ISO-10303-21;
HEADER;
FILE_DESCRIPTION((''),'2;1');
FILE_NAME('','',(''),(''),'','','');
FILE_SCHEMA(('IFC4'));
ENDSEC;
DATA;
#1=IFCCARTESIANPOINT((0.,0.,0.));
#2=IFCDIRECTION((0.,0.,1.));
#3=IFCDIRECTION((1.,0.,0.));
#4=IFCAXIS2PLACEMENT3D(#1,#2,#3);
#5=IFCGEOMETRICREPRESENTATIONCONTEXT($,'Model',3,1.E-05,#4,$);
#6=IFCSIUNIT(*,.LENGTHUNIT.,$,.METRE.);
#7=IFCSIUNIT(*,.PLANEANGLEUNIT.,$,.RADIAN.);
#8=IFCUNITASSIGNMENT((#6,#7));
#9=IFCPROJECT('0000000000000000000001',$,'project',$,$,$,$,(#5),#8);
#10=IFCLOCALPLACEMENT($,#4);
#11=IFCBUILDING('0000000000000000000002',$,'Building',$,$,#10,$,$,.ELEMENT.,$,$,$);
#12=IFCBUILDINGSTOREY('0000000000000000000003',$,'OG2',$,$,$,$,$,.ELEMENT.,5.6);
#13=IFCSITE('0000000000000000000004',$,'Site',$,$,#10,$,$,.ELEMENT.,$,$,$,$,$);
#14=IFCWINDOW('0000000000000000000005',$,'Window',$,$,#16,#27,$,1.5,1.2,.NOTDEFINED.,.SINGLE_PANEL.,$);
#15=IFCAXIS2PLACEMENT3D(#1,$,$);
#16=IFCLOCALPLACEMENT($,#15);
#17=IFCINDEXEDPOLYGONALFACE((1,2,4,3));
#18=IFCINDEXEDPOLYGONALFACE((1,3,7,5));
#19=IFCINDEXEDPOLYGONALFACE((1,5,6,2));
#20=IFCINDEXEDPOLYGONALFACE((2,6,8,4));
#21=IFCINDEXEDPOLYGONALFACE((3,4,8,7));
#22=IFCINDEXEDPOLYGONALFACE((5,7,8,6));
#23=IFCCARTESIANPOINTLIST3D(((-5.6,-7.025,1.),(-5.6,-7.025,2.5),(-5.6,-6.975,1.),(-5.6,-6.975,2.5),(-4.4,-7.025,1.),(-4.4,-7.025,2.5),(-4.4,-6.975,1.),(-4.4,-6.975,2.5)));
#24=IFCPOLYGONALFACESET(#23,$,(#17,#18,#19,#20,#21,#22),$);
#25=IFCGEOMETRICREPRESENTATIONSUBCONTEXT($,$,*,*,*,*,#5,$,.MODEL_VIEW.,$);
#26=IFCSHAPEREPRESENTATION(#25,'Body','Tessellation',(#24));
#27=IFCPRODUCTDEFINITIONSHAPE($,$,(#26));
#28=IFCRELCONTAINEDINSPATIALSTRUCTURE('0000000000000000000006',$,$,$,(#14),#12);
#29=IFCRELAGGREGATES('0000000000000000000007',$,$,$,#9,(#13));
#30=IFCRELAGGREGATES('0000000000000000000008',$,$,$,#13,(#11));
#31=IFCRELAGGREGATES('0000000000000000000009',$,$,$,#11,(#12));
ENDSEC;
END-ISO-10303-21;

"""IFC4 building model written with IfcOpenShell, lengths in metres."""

from ifc_helpers import new_model, si_unit, frame, origin, origin_with_axes, origin_2d, place, context, subcontext, project, spatial, rectangle, extrude, element, save


model = new_model("IFC4")

# Units and contexts
model_context = context("Model", 3, precision=1e-05, world=origin_with_axes())
sub_context = subcontext(model_context, None, None, "MODEL_VIEW")
ifc_project = project(units=[si_unit("LENGTHUNIT", "METRE"), si_unit("PLANEANGLEUNIT", "RADIAN")], contexts=[model_context])

# Site, building, storey
placement_1 = place(None, origin_with_axes())
site = spatial("IfcSite", under=ifc_project, at=placement_1, Name="Site", CompositionType="ELEMENT")
building = spatial("IfcBuilding", under=site, at=placement_1, Name="Building", CompositionType="ELEMENT")
storey = spatial("IfcBuildingStorey", under=building, Name="OG2", CompositionType="ELEMENT", Elevation=5.6)

# Window
placement_2 = place(None, origin_with_axes())
window_placement = place(placement_2, frame((-5.0, -7.0, 1.0)))
element("IfcWindow", 1, at=window_placement, inside=storey, Name="Window", OverallHeight=1.5, OverallWidth=1.2, PartitioningType="SINGLE_PANEL", PredefinedType="NOTDEFINED", context=sub_context, shape_type="SweptSolid", body=[
    extrude(rectangle(XDim=1.2, YDim=0.05, at=origin_2d()), origin(), (0.0, 0.0, 1.0), 1.5),
])

save(model, "model.ifc")
